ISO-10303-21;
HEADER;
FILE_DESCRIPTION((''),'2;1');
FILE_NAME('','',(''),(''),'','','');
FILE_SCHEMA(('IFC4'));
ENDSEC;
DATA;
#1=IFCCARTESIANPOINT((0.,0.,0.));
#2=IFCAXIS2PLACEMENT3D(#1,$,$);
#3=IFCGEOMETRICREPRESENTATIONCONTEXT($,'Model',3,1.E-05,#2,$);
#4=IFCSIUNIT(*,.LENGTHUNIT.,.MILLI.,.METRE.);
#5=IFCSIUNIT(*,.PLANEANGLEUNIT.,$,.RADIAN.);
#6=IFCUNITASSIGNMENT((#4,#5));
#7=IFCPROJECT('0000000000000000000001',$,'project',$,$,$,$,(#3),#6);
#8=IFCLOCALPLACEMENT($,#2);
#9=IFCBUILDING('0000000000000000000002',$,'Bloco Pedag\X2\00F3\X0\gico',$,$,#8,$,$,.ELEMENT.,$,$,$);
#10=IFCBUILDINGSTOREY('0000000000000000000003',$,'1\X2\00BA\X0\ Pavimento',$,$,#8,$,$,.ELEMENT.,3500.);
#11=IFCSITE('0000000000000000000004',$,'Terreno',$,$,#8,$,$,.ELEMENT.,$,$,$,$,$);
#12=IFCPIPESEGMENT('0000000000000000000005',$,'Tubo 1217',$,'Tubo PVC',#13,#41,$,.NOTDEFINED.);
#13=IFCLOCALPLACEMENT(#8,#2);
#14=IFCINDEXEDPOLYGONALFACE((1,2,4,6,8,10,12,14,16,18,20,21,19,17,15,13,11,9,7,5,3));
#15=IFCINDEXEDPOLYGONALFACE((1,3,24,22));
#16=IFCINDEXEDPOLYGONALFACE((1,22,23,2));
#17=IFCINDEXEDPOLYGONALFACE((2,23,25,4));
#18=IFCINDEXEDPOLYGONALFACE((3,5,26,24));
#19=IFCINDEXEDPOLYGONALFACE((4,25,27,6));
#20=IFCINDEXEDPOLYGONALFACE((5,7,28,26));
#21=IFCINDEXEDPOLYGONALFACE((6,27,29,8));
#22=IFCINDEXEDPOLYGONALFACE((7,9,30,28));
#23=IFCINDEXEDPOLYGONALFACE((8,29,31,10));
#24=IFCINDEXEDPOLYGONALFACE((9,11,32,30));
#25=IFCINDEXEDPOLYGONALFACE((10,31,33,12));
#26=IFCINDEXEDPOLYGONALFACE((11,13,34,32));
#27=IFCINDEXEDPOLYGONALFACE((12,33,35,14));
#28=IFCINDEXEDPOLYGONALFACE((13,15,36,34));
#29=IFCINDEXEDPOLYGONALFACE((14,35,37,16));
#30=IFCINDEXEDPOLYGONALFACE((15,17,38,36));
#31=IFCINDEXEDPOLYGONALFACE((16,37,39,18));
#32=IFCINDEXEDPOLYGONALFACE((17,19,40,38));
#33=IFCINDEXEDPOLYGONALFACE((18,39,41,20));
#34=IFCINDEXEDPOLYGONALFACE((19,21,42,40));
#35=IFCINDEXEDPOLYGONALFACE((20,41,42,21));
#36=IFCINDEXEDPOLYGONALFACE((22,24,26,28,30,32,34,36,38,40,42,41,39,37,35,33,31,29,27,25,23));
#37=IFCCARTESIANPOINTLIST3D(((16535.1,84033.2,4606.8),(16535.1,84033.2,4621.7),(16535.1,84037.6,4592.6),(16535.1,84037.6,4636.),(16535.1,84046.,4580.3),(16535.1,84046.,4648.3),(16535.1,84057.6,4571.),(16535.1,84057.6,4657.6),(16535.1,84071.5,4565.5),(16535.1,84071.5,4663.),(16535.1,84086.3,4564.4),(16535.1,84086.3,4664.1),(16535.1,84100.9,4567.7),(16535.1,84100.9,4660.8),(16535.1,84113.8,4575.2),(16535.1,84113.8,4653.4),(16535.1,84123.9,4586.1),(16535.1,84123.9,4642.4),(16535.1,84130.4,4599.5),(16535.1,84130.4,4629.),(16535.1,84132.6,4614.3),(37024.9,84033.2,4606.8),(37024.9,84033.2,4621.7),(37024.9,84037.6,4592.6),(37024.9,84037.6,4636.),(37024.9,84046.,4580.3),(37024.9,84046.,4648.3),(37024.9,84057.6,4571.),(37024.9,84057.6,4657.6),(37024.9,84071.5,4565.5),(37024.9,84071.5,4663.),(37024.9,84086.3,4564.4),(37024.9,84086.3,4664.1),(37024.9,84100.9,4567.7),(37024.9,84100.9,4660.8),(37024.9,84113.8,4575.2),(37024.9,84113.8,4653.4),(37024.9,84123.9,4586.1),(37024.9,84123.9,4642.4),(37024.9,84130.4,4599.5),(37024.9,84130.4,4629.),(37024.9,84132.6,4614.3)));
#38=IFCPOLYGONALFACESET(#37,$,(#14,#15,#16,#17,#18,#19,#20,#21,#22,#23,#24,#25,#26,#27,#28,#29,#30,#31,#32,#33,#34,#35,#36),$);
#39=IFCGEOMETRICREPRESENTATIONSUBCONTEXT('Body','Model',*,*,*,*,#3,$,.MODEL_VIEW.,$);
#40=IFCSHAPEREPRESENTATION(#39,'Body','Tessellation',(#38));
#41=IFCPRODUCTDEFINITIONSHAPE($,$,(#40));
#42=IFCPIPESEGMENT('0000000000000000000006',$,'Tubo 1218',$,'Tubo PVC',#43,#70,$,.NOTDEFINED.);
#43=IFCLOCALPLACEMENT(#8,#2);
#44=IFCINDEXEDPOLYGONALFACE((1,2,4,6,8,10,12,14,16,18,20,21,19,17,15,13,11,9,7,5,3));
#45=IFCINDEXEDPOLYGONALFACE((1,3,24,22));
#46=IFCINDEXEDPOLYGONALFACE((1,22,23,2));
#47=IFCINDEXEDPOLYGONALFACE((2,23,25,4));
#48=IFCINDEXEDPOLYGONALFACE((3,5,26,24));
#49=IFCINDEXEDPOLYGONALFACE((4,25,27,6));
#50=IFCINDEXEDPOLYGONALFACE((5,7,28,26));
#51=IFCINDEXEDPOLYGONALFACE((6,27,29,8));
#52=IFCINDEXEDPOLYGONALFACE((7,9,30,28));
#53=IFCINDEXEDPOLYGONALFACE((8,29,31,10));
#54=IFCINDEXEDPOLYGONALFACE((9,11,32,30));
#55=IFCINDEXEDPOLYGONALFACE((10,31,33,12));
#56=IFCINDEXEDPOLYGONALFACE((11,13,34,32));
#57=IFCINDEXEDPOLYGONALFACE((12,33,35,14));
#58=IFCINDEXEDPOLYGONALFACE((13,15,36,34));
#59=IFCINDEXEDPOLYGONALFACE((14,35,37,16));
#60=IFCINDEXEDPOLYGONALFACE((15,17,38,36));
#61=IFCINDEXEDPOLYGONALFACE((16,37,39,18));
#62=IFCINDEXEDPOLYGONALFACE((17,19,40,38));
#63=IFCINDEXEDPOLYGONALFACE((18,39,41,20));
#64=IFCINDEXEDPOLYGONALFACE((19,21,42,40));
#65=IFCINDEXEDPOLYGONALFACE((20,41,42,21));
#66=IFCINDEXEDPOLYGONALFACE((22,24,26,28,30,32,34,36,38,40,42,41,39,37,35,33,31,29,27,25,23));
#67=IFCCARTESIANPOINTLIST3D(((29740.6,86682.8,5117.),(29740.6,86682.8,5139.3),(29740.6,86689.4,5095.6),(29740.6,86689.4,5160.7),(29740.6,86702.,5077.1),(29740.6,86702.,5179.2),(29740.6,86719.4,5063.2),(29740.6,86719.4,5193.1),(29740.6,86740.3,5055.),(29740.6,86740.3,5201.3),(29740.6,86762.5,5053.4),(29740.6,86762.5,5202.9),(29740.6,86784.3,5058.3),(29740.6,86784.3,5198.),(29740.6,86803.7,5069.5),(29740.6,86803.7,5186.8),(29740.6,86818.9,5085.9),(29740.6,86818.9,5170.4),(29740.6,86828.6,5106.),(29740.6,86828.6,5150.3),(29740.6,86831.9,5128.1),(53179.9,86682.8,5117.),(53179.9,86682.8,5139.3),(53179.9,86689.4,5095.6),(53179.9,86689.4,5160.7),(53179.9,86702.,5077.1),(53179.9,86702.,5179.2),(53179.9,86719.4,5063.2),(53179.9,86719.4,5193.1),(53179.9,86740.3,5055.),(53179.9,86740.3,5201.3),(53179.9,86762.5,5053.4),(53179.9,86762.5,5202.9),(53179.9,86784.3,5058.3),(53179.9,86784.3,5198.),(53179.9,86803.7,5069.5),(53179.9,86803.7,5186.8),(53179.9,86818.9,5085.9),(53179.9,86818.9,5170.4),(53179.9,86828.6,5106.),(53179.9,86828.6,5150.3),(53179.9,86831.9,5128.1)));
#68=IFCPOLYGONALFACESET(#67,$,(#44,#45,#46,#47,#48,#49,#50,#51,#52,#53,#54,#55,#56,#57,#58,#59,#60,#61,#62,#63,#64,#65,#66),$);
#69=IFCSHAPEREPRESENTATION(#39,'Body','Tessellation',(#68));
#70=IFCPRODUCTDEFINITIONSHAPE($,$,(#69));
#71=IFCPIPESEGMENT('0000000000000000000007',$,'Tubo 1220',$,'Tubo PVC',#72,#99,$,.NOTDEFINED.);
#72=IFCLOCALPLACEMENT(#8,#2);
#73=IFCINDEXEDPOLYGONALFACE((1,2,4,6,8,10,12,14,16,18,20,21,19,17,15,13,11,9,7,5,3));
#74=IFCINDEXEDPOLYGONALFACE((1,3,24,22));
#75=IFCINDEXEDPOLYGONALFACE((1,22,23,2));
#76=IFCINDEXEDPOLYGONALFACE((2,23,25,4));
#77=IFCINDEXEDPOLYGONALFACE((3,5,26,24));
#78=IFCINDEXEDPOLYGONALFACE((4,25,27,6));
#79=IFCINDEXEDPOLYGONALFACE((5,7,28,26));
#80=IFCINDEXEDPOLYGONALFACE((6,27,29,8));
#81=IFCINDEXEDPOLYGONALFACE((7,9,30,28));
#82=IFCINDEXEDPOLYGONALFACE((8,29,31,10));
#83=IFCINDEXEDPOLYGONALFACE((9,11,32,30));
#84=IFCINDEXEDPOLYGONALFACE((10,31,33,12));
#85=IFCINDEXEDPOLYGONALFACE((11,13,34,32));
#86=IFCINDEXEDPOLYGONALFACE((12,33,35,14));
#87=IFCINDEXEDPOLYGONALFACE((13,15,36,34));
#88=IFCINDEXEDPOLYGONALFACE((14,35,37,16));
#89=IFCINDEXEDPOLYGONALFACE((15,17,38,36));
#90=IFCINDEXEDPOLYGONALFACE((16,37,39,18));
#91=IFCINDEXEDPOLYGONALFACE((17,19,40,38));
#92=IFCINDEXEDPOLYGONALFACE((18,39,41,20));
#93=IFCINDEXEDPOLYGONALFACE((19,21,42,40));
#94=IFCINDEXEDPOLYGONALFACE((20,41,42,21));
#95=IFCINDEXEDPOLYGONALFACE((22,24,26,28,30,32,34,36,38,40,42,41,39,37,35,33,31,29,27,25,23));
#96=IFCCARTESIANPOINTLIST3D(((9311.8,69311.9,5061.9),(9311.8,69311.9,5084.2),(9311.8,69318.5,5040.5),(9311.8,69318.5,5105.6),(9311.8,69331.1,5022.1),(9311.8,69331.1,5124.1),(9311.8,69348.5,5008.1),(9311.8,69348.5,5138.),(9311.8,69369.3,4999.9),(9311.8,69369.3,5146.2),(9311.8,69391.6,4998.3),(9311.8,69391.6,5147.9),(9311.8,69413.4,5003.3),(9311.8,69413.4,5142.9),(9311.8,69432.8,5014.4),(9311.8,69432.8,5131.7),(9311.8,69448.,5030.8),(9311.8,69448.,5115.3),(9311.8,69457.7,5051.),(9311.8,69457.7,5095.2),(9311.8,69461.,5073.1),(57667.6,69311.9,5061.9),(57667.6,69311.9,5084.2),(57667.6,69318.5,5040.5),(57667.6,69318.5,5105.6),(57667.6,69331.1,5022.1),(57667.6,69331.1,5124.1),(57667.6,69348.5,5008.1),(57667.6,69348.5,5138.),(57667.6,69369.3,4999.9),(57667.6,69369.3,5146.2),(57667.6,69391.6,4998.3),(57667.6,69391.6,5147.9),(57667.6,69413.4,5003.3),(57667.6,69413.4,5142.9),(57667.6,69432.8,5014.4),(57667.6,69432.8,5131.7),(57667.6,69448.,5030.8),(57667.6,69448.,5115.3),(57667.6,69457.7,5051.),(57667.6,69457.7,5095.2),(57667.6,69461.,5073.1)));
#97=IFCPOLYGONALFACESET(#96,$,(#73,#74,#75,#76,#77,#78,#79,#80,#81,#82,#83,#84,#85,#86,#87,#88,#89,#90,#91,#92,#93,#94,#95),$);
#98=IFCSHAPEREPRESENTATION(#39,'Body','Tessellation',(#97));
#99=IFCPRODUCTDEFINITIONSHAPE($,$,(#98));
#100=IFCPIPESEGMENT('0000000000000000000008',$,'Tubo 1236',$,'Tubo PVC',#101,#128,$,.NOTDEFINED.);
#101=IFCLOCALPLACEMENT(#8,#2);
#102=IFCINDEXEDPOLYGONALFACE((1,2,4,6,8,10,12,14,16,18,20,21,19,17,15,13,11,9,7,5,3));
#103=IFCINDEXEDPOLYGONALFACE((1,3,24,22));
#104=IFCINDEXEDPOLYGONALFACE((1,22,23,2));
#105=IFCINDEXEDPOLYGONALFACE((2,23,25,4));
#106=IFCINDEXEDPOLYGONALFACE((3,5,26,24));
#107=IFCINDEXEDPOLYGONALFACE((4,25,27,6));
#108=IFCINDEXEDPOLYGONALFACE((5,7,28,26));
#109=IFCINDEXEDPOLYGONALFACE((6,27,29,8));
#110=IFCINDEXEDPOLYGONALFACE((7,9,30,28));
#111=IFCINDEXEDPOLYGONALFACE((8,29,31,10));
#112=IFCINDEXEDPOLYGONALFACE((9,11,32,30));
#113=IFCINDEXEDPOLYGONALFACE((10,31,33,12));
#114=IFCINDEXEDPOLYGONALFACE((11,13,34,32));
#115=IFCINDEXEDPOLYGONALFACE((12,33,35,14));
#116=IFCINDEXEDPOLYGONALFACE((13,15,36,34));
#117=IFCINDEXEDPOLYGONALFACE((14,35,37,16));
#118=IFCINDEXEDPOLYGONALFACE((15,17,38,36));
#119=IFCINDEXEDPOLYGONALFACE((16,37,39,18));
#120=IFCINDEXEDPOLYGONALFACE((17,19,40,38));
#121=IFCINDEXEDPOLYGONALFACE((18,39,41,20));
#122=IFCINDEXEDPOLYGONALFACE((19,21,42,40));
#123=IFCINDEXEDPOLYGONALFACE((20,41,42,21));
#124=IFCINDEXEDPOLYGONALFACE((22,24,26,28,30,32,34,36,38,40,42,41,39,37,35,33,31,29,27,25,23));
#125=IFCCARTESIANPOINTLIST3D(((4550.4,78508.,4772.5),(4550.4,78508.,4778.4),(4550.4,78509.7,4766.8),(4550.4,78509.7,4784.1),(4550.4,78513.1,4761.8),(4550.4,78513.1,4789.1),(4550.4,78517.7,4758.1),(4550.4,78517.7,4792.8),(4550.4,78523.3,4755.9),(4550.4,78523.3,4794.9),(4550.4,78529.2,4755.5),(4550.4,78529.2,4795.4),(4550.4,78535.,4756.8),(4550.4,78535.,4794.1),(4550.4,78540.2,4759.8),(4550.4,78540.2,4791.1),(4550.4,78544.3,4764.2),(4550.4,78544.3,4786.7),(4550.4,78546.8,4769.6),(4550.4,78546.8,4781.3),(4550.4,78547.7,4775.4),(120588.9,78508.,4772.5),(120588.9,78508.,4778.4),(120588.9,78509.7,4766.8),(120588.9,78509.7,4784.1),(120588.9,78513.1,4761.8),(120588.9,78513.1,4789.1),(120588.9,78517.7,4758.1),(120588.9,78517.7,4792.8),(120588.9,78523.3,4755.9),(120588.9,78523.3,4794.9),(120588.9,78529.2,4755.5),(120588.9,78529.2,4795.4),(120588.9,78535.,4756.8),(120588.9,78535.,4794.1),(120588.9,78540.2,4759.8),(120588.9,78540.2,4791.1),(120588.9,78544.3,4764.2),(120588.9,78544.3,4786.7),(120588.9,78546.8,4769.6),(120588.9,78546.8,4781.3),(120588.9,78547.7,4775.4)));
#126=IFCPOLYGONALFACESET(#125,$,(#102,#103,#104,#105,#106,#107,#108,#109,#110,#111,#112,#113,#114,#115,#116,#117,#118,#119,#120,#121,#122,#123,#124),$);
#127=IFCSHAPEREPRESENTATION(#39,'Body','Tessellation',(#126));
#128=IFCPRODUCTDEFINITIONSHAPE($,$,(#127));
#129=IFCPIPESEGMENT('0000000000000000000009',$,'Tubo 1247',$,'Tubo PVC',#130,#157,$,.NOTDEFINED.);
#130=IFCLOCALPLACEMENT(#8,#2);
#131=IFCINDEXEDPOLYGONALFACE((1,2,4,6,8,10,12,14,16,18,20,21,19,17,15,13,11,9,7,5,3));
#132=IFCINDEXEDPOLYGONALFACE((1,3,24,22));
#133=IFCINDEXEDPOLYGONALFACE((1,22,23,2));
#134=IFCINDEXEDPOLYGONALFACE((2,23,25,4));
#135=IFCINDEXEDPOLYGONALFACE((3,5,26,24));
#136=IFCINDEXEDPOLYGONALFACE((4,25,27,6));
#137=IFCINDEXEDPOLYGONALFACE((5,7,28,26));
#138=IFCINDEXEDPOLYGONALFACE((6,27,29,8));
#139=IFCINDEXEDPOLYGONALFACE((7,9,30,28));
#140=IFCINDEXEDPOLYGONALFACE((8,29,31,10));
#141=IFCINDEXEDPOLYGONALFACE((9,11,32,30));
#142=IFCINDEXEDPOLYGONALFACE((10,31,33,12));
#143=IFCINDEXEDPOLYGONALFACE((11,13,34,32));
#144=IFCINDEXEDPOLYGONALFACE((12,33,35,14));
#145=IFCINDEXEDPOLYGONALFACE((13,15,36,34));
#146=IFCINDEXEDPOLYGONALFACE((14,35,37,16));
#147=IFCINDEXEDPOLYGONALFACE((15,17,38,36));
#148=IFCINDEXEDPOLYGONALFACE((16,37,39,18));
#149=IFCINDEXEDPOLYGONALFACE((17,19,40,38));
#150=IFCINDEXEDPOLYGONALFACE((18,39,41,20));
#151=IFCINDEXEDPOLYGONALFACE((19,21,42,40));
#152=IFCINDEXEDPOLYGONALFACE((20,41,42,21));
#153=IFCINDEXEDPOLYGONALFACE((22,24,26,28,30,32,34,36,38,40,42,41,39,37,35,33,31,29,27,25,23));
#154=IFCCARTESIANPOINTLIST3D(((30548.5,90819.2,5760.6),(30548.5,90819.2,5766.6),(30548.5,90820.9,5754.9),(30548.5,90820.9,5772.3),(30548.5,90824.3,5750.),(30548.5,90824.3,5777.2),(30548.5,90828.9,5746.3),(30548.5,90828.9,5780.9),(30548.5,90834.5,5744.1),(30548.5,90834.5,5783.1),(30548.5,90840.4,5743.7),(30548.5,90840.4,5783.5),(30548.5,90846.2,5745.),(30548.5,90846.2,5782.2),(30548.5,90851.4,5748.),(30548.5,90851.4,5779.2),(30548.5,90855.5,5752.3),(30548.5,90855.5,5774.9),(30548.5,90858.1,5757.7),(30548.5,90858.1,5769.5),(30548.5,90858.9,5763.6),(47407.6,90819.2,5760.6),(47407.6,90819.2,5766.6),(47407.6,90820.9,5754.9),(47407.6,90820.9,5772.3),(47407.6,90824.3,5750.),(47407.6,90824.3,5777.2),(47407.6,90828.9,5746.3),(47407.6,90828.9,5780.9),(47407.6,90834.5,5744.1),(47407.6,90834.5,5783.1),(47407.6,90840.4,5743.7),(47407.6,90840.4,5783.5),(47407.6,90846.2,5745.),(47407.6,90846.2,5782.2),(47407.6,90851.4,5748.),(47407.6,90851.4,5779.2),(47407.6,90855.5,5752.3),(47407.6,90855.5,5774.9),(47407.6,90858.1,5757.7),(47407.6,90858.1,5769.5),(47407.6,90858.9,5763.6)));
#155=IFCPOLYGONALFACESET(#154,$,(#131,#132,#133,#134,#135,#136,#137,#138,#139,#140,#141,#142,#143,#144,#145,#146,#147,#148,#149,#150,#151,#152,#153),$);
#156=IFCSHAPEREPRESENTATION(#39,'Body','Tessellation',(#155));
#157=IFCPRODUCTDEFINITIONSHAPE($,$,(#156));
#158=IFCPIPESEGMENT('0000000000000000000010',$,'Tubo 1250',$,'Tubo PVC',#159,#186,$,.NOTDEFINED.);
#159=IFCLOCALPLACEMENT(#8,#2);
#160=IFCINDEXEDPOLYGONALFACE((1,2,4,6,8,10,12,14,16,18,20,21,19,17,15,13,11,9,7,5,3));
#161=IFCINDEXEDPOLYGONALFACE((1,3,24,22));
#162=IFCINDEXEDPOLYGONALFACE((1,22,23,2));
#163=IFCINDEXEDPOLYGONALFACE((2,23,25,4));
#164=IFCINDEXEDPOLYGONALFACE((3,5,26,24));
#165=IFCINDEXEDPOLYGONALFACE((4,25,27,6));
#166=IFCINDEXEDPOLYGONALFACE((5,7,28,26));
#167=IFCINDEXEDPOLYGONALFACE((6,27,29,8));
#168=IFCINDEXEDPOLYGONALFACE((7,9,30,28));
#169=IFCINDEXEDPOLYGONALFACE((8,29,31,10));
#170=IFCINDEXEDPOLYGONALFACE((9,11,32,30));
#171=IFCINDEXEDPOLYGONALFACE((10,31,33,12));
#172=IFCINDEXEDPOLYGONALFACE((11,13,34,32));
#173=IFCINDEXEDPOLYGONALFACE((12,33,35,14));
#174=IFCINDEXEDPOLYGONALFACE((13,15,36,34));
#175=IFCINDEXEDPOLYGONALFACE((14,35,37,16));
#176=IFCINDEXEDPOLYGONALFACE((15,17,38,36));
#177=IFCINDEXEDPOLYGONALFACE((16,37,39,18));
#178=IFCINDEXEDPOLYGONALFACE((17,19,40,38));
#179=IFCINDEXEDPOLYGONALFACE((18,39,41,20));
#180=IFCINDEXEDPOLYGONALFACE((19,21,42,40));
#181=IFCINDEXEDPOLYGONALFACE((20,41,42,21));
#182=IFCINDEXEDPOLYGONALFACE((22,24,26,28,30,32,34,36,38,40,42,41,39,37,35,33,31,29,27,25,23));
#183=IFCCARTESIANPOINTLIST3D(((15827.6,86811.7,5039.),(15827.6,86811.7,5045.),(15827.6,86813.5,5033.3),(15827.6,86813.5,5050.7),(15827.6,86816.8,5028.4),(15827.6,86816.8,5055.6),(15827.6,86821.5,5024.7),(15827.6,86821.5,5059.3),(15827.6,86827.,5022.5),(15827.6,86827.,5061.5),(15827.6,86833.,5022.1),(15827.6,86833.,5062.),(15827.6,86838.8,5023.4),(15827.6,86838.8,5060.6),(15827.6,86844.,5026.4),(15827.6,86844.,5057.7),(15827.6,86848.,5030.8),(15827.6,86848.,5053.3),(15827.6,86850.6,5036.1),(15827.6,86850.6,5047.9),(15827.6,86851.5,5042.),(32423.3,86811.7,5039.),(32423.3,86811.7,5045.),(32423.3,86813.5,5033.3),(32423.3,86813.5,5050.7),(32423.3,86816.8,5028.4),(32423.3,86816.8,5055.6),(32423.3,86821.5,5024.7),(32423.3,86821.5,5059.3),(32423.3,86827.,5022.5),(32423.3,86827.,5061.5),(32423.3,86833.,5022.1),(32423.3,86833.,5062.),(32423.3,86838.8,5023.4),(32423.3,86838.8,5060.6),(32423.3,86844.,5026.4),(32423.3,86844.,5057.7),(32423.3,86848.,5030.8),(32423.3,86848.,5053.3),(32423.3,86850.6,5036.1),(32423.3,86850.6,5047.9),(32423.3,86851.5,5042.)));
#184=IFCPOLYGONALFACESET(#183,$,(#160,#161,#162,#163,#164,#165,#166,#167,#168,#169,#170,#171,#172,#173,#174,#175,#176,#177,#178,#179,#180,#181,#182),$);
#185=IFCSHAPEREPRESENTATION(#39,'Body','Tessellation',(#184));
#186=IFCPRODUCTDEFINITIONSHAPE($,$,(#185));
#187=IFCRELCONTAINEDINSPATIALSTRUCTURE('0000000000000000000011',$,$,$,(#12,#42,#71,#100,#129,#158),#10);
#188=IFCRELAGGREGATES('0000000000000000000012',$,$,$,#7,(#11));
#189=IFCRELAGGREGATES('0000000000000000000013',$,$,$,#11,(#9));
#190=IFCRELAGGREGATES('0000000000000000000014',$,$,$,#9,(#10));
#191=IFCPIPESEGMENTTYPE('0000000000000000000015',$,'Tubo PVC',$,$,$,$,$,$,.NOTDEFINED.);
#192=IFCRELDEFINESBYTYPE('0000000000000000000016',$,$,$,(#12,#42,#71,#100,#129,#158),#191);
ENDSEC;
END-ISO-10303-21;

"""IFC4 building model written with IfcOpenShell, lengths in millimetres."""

from ifc_helpers import new_model, si_unit, frame, origin, origin_2d, place, context, subcontext, project, spatial, circle, extrude, type_object, element, save


model = new_model("IFC4")

# Units and contexts
model_context = context("Model", 3, precision=1e-05, world=origin())
body_context = subcontext(model_context, "Body", "Model", "MODEL_VIEW")
ifc_project = project(units=[si_unit("LENGTHUNIT", "METRE", prefix="MILLI"), si_unit("PLANEANGLEUNIT", "RADIAN")], contexts=[model_context])

# Site, building, storey
placement = place(None, origin())
site = spatial("IfcSite", under=ifc_project, at=placement, Name="Terreno", CompositionType="ELEMENT")
building = spatial("IfcBuilding", under=site, at=placement, Name="Bloco Pedagógico", CompositionType="ELEMENT")
storey = spatial("IfcBuildingStorey", under=building, at=placement, Name="1º Pavimento", CompositionType="ELEMENT", Elevation=3500.0)

# Pipe segments
pipe_segment_type = type_object("IfcPipeSegmentType", Name="Tubo PVC", PredefinedType="NOTDEFINED")
pipe_segment_1_placement = place(None, frame((16535.1, 84082.6, 4614.3), z_axis=(1.0, 0.0, 0.0), x_axis=(0.0, 1.0, 0.0)))
element("IfcPipeSegment", 1, at=pipe_segment_1_placement, inside=storey, type_object=pipe_segment_type, Name="Tubo 1217", ObjectType="Tubo PVC", PredefinedType="NOTDEFINED", context=body_context, shape_type="SweptSolid", body=[
    extrude(circle(Radius=50.0, at=origin_2d()), None, (0.0, 0.0, 1.0), 20489.8),
])
pipe_segment_2_placement = place(None, frame((29740.6, 86756.9, 5128.1), z_axis=(1.0, 0.0, 0.0), x_axis=(0.0, 1.0, 0.0)))
element("IfcPipeSegment", 2, at=pipe_segment_2_placement, inside=storey, type_object=pipe_segment_type, Name="Tubo 1218", ObjectType="Tubo PVC", PredefinedType="NOTDEFINED", context=body_context, shape_type="SweptSolid", body=[
    extrude(circle(Radius=75.0, at=origin_2d()), None, (0.0, 0.0, 1.0), 23439.3),
])
pipe_segment_3_placement = place(None, frame((9311.8, 69386.0, 5073.1), z_axis=(1.0, 0.0, 0.0), x_axis=(0.0, 1.0, 0.0)))
element("IfcPipeSegment", 3, at=pipe_segment_3_placement, inside=storey, type_object=pipe_segment_type, Name="Tubo 1220", ObjectType="Tubo PVC", PredefinedType="NOTDEFINED", context=body_context, shape_type="SweptSolid", body=[
    extrude(circle(Radius=75.0, at=origin_2d()), None, (0.0, 0.0, 1.0), 48355.8),
])
pipe_segment_4_placement = place(None, frame((4550.4, 78527.7, 4775.4), z_axis=(1.0, 0.0, 0.0), x_axis=(0.0, 1.0, 0.0)))
element("IfcPipeSegment", 4, at=pipe_segment_4_placement, inside=storey, type_object=pipe_segment_type, Name="Tubo 1236", ObjectType="Tubo PVC", PredefinedType="NOTDEFINED", context=body_context, shape_type="SweptSolid", body=[
    extrude(circle(Radius=20.0, at=origin_2d()), None, (0.0, 0.0, 1.0), 116038.4),
])
pipe_segment_5_placement = place(None, frame((30548.5, 90838.9, 5763.6), z_axis=(1.0, 0.0, 0.0), x_axis=(0.0, 1.0, 0.0)))
element("IfcPipeSegment", 5, at=pipe_segment_5_placement, inside=storey, type_object=pipe_segment_type, Name="Tubo 1247", ObjectType="Tubo PVC", PredefinedType="NOTDEFINED", context=body_context, shape_type="SweptSolid", body=[
    extrude(circle(Radius=20.0, at=origin_2d()), None, (0.0, 0.0, 1.0), 16859.1),
])
pipe_segment_6_placement = place(None, frame((15827.6, 86831.5, 5042.0), z_axis=(1.0, 0.0, 0.0), x_axis=(0.0, 1.0, 0.0)))
element("IfcPipeSegment", 6, at=pipe_segment_6_placement, inside=storey, type_object=pipe_segment_type, Name="Tubo 1250", ObjectType="Tubo PVC", PredefinedType="NOTDEFINED", context=body_context, shape_type="SweptSolid", body=[
    extrude(circle(Radius=20.0, at=origin_2d()), None, (0.0, 0.0, 1.0), 16595.7),
])

save(model, "model.ifc")
